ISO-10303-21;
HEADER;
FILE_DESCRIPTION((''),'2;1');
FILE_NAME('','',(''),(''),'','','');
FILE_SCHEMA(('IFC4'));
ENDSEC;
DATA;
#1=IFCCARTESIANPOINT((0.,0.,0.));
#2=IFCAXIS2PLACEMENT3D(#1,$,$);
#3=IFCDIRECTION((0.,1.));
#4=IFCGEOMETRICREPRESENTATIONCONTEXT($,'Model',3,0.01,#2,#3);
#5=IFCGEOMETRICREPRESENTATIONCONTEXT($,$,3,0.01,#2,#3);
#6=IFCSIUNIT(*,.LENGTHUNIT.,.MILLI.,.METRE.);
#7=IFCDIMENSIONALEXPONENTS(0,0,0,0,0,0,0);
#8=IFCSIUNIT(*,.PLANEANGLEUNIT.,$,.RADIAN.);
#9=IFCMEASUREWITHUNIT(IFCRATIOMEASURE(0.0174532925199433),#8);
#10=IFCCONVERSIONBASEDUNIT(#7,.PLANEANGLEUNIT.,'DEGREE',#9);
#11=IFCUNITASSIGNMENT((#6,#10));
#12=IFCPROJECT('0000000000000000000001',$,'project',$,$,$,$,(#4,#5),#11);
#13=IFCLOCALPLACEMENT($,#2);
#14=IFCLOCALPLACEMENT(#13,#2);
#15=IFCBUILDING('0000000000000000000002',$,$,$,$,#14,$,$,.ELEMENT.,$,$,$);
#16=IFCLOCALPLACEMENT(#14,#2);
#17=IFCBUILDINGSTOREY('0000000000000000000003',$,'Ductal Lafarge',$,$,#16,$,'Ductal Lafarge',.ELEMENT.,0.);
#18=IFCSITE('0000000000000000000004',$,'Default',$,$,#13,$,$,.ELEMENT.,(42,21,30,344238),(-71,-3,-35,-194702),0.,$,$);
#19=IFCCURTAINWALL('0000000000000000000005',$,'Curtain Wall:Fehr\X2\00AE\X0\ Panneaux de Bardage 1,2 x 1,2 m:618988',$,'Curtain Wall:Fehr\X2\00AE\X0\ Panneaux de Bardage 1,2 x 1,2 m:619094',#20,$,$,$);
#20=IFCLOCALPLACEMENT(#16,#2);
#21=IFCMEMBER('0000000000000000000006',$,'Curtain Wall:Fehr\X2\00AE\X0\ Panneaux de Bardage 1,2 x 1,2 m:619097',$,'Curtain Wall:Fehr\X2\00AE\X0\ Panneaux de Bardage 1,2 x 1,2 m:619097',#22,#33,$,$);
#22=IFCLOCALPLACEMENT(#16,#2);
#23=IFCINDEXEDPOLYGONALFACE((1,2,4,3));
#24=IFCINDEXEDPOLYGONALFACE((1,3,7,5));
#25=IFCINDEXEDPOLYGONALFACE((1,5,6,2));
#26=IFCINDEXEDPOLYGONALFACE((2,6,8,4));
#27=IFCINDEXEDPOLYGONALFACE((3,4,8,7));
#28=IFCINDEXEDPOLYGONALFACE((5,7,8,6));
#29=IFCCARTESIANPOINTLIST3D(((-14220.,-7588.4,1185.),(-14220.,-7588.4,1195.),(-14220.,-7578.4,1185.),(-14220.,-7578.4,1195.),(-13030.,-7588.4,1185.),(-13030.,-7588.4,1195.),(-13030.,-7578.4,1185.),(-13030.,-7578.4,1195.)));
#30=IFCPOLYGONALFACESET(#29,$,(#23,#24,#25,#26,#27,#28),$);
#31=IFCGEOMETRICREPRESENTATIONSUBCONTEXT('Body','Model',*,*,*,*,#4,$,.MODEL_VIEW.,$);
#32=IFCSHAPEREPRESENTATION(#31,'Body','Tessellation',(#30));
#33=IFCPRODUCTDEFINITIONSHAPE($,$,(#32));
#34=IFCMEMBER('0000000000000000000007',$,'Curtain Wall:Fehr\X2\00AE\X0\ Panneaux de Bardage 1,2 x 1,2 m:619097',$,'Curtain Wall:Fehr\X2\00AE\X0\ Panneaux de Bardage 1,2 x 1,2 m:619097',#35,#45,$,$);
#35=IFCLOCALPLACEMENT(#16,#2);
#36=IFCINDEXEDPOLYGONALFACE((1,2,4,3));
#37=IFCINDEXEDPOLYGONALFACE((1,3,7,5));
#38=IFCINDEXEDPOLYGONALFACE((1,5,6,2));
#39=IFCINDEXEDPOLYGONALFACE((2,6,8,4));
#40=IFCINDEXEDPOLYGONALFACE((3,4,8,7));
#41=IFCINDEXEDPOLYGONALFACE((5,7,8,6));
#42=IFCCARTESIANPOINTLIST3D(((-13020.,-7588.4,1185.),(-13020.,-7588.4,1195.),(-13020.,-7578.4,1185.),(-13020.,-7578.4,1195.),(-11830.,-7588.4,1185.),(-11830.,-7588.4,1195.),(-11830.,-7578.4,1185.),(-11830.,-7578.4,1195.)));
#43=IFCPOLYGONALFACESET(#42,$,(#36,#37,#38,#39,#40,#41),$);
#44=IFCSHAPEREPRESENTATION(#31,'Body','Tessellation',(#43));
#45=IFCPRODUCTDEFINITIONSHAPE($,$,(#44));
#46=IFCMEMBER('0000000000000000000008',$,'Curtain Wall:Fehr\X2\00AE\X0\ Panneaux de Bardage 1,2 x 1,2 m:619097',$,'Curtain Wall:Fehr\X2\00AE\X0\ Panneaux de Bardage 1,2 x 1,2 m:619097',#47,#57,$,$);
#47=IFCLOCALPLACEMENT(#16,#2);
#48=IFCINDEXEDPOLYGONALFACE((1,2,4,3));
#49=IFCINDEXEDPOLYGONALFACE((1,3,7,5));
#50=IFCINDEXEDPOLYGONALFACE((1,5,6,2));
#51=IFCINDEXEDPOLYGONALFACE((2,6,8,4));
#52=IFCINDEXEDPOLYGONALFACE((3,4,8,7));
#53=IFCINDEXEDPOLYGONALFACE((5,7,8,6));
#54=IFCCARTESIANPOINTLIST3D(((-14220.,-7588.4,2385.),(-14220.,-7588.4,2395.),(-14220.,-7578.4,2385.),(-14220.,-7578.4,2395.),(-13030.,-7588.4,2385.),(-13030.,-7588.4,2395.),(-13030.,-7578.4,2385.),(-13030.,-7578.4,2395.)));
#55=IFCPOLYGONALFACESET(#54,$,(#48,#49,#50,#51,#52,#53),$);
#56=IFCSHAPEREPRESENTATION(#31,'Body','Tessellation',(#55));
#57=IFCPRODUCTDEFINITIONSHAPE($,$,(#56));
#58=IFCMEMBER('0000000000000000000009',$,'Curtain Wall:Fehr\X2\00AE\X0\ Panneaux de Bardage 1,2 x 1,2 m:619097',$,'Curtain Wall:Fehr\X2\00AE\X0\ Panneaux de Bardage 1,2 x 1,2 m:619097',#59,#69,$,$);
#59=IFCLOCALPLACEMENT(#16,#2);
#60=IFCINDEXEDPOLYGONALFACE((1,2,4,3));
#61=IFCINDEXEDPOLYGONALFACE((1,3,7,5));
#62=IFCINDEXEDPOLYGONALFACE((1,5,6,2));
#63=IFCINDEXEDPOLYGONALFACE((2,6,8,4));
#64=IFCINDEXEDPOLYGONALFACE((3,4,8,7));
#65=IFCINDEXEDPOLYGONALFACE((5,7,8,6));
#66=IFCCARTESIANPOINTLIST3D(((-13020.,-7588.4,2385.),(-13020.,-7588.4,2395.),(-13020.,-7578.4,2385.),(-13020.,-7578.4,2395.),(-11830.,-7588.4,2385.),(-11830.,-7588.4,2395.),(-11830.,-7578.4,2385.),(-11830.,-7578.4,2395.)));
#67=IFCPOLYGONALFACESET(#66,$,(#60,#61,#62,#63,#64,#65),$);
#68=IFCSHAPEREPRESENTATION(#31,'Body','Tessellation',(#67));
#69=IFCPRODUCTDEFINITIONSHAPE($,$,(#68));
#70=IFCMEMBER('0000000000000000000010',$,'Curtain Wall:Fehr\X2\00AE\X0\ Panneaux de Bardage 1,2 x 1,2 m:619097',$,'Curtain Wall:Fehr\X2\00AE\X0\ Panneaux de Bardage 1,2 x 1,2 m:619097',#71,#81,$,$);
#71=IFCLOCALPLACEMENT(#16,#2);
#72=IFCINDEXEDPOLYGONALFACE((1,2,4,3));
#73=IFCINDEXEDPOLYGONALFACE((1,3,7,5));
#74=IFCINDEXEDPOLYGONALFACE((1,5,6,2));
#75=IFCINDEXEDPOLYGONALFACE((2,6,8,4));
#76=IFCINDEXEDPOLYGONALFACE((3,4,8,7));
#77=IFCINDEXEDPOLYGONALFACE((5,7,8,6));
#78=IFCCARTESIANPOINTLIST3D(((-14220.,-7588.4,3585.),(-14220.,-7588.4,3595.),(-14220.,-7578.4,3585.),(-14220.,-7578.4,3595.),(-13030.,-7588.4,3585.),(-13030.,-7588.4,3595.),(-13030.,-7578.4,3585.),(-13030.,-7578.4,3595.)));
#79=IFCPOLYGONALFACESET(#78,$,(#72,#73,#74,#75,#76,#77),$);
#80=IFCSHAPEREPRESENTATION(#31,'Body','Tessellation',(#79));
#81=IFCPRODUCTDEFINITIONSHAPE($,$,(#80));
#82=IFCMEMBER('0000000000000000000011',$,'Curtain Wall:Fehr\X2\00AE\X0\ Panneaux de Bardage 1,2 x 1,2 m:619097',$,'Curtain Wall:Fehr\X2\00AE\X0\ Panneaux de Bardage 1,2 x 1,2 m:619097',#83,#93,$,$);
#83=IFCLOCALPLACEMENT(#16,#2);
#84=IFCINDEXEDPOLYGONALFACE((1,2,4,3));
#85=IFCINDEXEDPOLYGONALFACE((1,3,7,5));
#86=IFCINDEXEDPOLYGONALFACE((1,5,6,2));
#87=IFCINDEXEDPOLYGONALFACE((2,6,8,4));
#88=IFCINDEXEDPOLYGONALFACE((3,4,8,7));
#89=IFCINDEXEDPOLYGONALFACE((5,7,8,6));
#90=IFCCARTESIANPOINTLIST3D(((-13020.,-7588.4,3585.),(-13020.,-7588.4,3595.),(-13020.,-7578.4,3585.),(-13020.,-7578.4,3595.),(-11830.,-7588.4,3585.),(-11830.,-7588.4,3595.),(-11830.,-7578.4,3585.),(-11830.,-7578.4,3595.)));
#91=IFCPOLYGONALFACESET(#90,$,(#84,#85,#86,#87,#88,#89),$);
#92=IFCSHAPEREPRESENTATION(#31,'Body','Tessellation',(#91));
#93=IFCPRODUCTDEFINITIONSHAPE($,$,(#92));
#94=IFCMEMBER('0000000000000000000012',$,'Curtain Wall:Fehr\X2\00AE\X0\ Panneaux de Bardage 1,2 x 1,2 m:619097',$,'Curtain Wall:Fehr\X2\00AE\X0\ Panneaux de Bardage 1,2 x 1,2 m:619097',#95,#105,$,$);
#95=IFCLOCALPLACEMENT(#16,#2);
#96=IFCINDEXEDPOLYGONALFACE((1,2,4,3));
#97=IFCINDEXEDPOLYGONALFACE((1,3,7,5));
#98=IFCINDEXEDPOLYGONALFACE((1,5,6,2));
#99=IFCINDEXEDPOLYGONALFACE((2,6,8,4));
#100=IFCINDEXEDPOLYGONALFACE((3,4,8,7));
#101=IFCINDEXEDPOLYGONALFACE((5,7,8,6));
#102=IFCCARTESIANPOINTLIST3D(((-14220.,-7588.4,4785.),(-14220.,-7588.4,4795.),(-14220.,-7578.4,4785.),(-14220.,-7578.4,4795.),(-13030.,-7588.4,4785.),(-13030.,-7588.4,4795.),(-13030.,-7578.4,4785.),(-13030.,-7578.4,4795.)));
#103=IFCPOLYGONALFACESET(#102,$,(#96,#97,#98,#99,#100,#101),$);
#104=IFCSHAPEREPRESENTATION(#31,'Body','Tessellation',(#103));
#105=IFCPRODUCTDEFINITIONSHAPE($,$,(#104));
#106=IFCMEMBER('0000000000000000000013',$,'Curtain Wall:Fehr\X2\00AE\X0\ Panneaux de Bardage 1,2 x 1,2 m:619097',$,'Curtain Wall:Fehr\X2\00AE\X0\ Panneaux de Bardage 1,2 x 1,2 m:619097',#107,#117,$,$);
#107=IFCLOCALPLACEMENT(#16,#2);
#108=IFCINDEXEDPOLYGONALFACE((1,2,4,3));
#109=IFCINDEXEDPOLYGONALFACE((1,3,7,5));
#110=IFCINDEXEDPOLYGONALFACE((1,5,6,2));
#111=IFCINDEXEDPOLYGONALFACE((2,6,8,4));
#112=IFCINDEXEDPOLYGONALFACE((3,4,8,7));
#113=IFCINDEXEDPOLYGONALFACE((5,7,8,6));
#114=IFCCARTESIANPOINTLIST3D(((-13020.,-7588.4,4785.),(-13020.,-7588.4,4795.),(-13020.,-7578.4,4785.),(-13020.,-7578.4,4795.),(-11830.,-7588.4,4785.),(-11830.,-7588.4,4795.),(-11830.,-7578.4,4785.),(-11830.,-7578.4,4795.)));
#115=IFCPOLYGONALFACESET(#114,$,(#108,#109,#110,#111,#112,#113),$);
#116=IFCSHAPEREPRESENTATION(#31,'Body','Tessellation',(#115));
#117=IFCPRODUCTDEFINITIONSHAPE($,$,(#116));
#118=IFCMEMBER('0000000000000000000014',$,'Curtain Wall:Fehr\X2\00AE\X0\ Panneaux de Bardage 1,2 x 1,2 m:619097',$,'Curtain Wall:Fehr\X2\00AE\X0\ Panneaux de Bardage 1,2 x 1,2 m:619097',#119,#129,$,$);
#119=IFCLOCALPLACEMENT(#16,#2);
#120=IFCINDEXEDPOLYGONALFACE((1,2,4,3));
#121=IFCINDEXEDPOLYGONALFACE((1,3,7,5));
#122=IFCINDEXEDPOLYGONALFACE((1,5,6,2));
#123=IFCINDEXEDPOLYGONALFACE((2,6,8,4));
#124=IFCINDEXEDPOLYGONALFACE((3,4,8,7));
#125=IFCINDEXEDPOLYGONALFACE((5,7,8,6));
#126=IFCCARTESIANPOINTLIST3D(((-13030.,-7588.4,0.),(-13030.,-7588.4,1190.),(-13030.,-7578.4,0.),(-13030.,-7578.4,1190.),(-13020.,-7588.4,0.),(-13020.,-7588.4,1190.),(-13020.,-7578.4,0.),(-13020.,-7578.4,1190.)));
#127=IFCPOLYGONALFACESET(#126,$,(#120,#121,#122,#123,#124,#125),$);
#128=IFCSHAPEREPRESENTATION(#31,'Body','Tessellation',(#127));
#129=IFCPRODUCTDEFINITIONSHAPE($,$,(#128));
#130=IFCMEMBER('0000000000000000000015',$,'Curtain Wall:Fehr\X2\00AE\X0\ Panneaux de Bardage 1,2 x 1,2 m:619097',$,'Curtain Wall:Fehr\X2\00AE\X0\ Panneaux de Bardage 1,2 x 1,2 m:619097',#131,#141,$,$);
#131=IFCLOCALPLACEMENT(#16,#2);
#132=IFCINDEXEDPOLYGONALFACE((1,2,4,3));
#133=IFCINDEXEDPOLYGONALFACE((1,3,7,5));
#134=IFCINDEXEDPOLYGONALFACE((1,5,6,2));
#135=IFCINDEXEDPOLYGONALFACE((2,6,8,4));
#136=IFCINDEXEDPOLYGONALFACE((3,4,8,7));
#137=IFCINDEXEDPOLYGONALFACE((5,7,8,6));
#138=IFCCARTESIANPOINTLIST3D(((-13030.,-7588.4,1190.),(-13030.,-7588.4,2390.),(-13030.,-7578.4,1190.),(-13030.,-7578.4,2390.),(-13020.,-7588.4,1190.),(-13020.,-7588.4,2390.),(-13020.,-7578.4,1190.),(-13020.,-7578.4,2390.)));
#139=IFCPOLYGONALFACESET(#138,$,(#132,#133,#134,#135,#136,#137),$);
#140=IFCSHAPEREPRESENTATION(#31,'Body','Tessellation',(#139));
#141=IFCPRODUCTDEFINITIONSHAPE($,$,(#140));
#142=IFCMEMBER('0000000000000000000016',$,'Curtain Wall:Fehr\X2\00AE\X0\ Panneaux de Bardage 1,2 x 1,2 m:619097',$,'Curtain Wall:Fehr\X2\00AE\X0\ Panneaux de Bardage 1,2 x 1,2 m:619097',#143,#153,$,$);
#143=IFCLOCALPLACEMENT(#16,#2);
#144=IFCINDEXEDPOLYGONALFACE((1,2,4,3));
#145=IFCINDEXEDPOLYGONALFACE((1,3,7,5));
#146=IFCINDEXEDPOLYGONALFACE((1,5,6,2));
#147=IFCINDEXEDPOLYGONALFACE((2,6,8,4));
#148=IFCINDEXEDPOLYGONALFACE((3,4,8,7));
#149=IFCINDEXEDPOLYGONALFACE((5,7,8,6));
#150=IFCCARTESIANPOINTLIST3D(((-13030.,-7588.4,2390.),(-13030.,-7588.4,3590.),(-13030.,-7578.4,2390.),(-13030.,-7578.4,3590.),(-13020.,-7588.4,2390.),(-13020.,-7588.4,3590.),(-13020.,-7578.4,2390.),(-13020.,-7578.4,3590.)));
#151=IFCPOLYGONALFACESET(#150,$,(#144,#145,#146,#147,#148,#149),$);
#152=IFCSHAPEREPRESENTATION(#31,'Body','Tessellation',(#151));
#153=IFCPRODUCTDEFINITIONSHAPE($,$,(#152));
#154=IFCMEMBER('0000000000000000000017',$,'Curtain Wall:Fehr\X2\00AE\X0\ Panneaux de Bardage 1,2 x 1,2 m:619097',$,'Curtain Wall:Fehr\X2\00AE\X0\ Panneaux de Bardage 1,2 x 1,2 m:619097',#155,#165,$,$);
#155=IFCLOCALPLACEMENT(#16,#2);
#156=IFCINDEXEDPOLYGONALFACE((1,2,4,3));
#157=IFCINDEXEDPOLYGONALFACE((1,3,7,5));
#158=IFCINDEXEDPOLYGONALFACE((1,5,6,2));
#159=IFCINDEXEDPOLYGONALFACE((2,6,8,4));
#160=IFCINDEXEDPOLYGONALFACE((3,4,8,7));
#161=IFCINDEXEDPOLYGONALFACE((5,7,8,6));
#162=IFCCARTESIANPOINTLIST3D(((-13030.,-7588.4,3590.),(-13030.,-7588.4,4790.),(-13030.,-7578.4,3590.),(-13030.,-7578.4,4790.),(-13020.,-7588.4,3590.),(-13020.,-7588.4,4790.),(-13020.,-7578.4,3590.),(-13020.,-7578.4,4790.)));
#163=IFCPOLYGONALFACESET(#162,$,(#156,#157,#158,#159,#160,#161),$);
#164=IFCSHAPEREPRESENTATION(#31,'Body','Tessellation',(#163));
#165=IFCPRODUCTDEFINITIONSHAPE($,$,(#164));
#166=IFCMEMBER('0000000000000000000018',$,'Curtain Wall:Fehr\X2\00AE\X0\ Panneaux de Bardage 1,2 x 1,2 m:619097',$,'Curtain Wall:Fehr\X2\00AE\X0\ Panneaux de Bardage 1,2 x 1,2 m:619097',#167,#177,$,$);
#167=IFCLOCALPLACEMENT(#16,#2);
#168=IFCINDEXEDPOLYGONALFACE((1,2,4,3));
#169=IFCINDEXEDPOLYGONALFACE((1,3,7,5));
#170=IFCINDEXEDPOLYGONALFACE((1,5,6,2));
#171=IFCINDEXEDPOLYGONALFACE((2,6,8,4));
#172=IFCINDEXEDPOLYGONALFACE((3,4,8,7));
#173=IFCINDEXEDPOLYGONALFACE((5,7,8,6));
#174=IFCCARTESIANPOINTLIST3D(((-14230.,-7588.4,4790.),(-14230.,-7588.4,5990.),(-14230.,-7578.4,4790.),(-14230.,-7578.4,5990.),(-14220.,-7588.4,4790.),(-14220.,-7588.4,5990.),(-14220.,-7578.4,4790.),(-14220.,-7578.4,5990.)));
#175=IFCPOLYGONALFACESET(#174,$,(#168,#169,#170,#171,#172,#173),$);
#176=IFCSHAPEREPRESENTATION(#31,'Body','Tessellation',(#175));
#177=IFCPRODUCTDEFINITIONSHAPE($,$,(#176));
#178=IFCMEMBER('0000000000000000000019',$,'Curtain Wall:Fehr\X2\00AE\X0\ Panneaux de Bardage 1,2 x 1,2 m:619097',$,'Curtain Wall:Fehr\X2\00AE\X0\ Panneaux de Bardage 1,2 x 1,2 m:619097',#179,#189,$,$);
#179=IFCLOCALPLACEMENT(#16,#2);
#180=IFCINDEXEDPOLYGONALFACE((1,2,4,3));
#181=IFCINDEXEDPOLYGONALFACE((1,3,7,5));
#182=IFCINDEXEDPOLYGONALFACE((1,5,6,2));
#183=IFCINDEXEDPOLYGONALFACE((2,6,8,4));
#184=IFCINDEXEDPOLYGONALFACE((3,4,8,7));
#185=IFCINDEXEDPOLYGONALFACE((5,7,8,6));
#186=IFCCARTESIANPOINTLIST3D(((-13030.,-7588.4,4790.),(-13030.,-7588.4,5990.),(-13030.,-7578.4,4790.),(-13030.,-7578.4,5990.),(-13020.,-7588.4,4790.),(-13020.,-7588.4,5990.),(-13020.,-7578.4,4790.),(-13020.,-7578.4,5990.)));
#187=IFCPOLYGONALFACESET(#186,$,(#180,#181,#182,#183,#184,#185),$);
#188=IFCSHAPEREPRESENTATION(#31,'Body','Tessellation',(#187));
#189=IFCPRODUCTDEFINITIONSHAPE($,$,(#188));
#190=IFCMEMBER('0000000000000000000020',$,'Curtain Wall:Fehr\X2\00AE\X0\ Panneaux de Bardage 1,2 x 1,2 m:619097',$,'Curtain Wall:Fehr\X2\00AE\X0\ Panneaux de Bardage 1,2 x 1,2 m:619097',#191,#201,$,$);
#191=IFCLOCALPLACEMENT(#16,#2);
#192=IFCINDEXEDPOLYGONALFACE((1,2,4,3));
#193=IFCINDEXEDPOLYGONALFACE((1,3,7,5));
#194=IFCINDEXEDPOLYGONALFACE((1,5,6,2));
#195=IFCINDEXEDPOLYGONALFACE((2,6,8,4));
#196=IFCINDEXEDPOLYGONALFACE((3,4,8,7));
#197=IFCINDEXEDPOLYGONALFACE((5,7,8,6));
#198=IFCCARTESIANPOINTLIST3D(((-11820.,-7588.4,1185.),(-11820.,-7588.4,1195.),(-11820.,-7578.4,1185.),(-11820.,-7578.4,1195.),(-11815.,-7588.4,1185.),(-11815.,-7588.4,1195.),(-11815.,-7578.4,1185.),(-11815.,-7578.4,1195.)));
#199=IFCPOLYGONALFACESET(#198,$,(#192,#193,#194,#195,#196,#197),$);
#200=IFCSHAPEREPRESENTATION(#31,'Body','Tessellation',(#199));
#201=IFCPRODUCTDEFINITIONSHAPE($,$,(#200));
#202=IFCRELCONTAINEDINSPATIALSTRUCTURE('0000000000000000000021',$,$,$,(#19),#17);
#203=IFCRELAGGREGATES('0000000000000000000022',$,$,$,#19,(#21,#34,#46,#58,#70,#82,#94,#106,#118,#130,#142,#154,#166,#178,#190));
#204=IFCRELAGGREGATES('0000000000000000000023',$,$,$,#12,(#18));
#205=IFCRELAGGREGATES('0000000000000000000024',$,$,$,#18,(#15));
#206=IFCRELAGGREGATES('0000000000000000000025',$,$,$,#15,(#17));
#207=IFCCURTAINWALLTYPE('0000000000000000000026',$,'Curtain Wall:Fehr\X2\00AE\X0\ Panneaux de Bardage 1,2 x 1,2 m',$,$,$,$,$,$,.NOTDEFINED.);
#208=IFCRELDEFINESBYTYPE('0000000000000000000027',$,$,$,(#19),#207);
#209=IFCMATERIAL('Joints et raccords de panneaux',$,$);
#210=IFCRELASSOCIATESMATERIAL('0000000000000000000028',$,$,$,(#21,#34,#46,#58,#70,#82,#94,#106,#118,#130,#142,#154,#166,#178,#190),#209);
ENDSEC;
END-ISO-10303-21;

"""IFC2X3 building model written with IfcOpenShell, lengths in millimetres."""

from ifc_helpers import new_model, entity, si_unit, converted_unit, direction, frame, frame_2d, origin, origin_2d_with_axis, place, context, subcontext, project, spatial, rectangle, extrude, material, type_object, element, aggregate, save


model = new_model("IFC2X3")

# Units and contexts
model_context = context("Model", 3, precision=0.01, world=origin(), true_north=direction((0.0, 1.0)))
context_of_model = context(None, 3, precision=0.01, world=origin(), true_north=direction((0.0, 1.0)))
body_context = subcontext(model_context, "Body", "Model", "MODEL_VIEW")
ifc_project = project(units=[si_unit("LENGTHUNIT", "METRE", prefix="MILLI"), converted_unit("PLANEANGLEUNIT", "DEGREE", entity("IfcRatioMeasure", 0.0174532925199433), si_unit("PLANEANGLEUNIT", "RADIAN"), dimensions=[0, 0, 0, 0, 0, 0, 0])], contexts=[model_context, context_of_model])

# Site, building, storey
site_placement = place(None, origin())
site = spatial("IfcSite", under=ifc_project, at=site_placement, Name="Default", CompositionType="ELEMENT", RefLatitude=(42, 21, 30, 344238), RefLongitude=(-71, -3, -35, -194702), RefElevation=0.0)
building_placement = place(site_placement, origin())
building = spatial("IfcBuilding", under=site, at=building_placement, CompositionType="ELEMENT")
storey_placement = place(building_placement, origin())
storey = spatial("IfcBuildingStorey", under=building, at=storey_placement, Name="Ductal Lafarge", LongName="Ductal Lafarge", CompositionType="ELEMENT", Elevation=0.0)

# Curtain wall, members
curtain_wall_type = type_object("IfcCurtainWallType", Name="Curtain Wall:Fehr® Panneaux de Bardage 1,2 x 1,2 m", PredefinedType="NOTDEFINED")
curtain_wall_placement = place(storey_placement, origin())
curtain_wall = element("IfcCurtainWall", 1, at=curtain_wall_placement, inside=storey, type_object=curtain_wall_type, Name="Curtain Wall:Fehr® Panneaux de Bardage 1,2 x 1,2 m:618988", ObjectType="Curtain Wall:Fehr® Panneaux de Bardage 1,2 x 1,2 m:619094")
ifc_material = material(Name="Joints et raccords de panneaux")
member_1_placement = place(curtain_wall_placement, frame((-14220.0, -7588.4, 1185.0)))
member_1 = element("IfcMember", 2, at=member_1_placement, material=ifc_material, Name="Curtain Wall:Fehr® Panneaux de Bardage 1,2 x 1,2 m:619097", ObjectType="Curtain Wall:Fehr® Panneaux de Bardage 1,2 x 1,2 m:619097", context=body_context, shape_type="SweptSolid", body=[
    extrude(rectangle(XDim=1190.0, YDim=10.0, at=frame_2d((0.0, 0.0), x_axis=(1.0, 0.0))), frame((595.0, 5.0, 0.0), z_axis=(0.0, 0.0, 1.0), x_axis=(-1.0, 0.0, 0.0)), (0.0, 0.0, 1.0), 10.0),
])
member_2_placement = place(curtain_wall_placement, frame((-13020.0, -7588.4, 1185.0)))
member_2 = element("IfcMember", 3, at=member_2_placement, material=ifc_material, Name="Curtain Wall:Fehr® Panneaux de Bardage 1,2 x 1,2 m:619097", ObjectType="Curtain Wall:Fehr® Panneaux de Bardage 1,2 x 1,2 m:619097", context=body_context, shape_type="SweptSolid", body=[
    extrude(rectangle(XDim=1190.0, YDim=10.0, at=frame_2d((0.0, 0.0), x_axis=(1.0, 0.0))), frame((595.0, 5.0, 0.0), z_axis=(0.0, 0.0, 1.0), x_axis=(-1.0, 0.0, 0.0)), (0.0, 0.0, 1.0), 10.0),
])
member_3_placement = place(curtain_wall_placement, frame((-14220.0, -7588.4, 2385.0)))
member_3 = element("IfcMember", 4, at=member_3_placement, material=ifc_material, Name="Curtain Wall:Fehr® Panneaux de Bardage 1,2 x 1,2 m:619097", ObjectType="Curtain Wall:Fehr® Panneaux de Bardage 1,2 x 1,2 m:619097", context=body_context, shape_type="SweptSolid", body=[
    extrude(rectangle(XDim=1190.0, YDim=10.0, at=frame_2d((0.0, 0.0), x_axis=(1.0, 0.0))), frame((595.0, 5.0, 0.0), z_axis=(0.0, 0.0, 1.0), x_axis=(-1.0, 0.0, 0.0)), (0.0, 0.0, 1.0), 10.0),
])
member_4_placement = place(curtain_wall_placement, frame((-13020.0, -7588.4, 2385.0)))
member_4 = element("IfcMember", 5, at=member_4_placement, material=ifc_material, Name="Curtain Wall:Fehr® Panneaux de Bardage 1,2 x 1,2 m:619097", ObjectType="Curtain Wall:Fehr® Panneaux de Bardage 1,2 x 1,2 m:619097", context=body_context, shape_type="SweptSolid", body=[
    extrude(rectangle(XDim=1190.0, YDim=10.0, at=frame_2d((0.0, 0.0), x_axis=(1.0, 0.0))), frame((595.0, 5.0, 0.0), z_axis=(0.0, 0.0, 1.0), x_axis=(-1.0, 0.0, 0.0)), (0.0, 0.0, 1.0), 10.0),
])
member_5_placement = place(curtain_wall_placement, frame((-14220.0, -7588.4, 3585.0)))
member_5 = element("IfcMember", 6, at=member_5_placement, material=ifc_material, Name="Curtain Wall:Fehr® Panneaux de Bardage 1,2 x 1,2 m:619097", ObjectType="Curtain Wall:Fehr® Panneaux de Bardage 1,2 x 1,2 m:619097", context=body_context, shape_type="SweptSolid", body=[
    extrude(rectangle(XDim=1190.0, YDim=10.0, at=frame_2d((0.0, 0.0), x_axis=(1.0, 0.0))), frame((595.0, 5.0, 0.0), z_axis=(0.0, 0.0, 1.0), x_axis=(-1.0, 0.0, 0.0)), (0.0, 0.0, 1.0), 10.0),
])
member_6_placement = place(curtain_wall_placement, frame((-13020.0, -7588.4, 3585.0)))
member_6 = element("IfcMember", 7, at=member_6_placement, material=ifc_material, Name="Curtain Wall:Fehr® Panneaux de Bardage 1,2 x 1,2 m:619097", ObjectType="Curtain Wall:Fehr® Panneaux de Bardage 1,2 x 1,2 m:619097", context=body_context, shape_type="SweptSolid", body=[
    extrude(rectangle(XDim=1190.0, YDim=10.0, at=frame_2d((0.0, 0.0), x_axis=(1.0, 0.0))), frame((595.0, 5.0, 0.0), z_axis=(0.0, 0.0, 1.0), x_axis=(-1.0, 0.0, 0.0)), (0.0, 0.0, 1.0), 10.0),
])
member_7_placement = place(curtain_wall_placement, frame((-14220.0, -7588.4, 4785.0)))
member_7 = element("IfcMember", 8, at=member_7_placement, material=ifc_material, Name="Curtain Wall:Fehr® Panneaux de Bardage 1,2 x 1,2 m:619097", ObjectType="Curtain Wall:Fehr® Panneaux de Bardage 1,2 x 1,2 m:619097", context=body_context, shape_type="SweptSolid", body=[
    extrude(rectangle(XDim=1190.0, YDim=10.0, at=frame_2d((0.0, 0.0), x_axis=(1.0, 0.0))), frame((595.0, 5.0, 0.0), z_axis=(0.0, 0.0, 1.0), x_axis=(-1.0, 0.0, 0.0)), (0.0, 0.0, 1.0), 10.0),
])
member_8_placement = place(curtain_wall_placement, frame((-13020.0, -7588.4, 4785.0)))
member_8 = element("IfcMember", 9, at=member_8_placement, material=ifc_material, Name="Curtain Wall:Fehr® Panneaux de Bardage 1,2 x 1,2 m:619097", ObjectType="Curtain Wall:Fehr® Panneaux de Bardage 1,2 x 1,2 m:619097", context=body_context, shape_type="SweptSolid", body=[
    extrude(rectangle(XDim=1190.0, YDim=10.0, at=frame_2d((0.0, 0.0), x_axis=(1.0, 0.0))), frame((595.0, 5.0, 0.0), z_axis=(0.0, 0.0, 1.0), x_axis=(-1.0, 0.0, 0.0)), (0.0, 0.0, 1.0), 10.0),
])
member_9_placement = place(curtain_wall_placement, frame((-13030.0, -7588.4, 0.0)))
member_9 = element("IfcMember", 10, at=member_9_placement, material=ifc_material, Name="Curtain Wall:Fehr® Panneaux de Bardage 1,2 x 1,2 m:619097", ObjectType="Curtain Wall:Fehr® Panneaux de Bardage 1,2 x 1,2 m:619097", context=body_context, shape_type="SweptSolid", body=[
    extrude(rectangle(XDim=10.0, YDim=10.0, at=origin_2d_with_axis()), frame((5.0, 5.0, 0.0), z_axis=(0.0, 0.0, 1.0), x_axis=(0.0, 1.0, 0.0)), (0.0, 0.0, 1.0), 1190.0),
])
member_10_placement = place(curtain_wall_placement, frame((-13030.0, -7588.4, 1190.0)))
member_10 = element("IfcMember", 11, at=member_10_placement, material=ifc_material, Name="Curtain Wall:Fehr® Panneaux de Bardage 1,2 x 1,2 m:619097", ObjectType="Curtain Wall:Fehr® Panneaux de Bardage 1,2 x 1,2 m:619097", context=body_context, shape_type="SweptSolid", body=[
    extrude(rectangle(XDim=10.0, YDim=10.0, at=origin_2d_with_axis()), frame((5.0, 5.0, 0.0), z_axis=(0.0, 0.0, 1.0), x_axis=(0.0, 1.0, 0.0)), (0.0, 0.0, 1.0), 1200.0),
])
member_11_placement = place(curtain_wall_placement, frame((-13030.0, -7588.4, 2390.0)))
member_11 = element("IfcMember", 12, at=member_11_placement, material=ifc_material, Name="Curtain Wall:Fehr® Panneaux de Bardage 1,2 x 1,2 m:619097", ObjectType="Curtain Wall:Fehr® Panneaux de Bardage 1,2 x 1,2 m:619097", context=body_context, shape_type="SweptSolid", body=[
    extrude(rectangle(XDim=10.0, YDim=10.0, at=origin_2d_with_axis()), frame((5.0, 5.0, 0.0), z_axis=(0.0, 0.0, 1.0), x_axis=(0.0, 1.0, 0.0)), (0.0, 0.0, 1.0), 1200.0),
])
member_12_placement = place(curtain_wall_placement, frame((-13030.0, -7588.4, 3590.0)))
member_12 = element("IfcMember", 13, at=member_12_placement, material=ifc_material, Name="Curtain Wall:Fehr® Panneaux de Bardage 1,2 x 1,2 m:619097", ObjectType="Curtain Wall:Fehr® Panneaux de Bardage 1,2 x 1,2 m:619097", context=body_context, shape_type="SweptSolid", body=[
    extrude(rectangle(XDim=10.0, YDim=10.0, at=origin_2d_with_axis()), frame((5.0, 5.0, 0.0), z_axis=(0.0, 0.0, 1.0), x_axis=(0.0, 1.0, 0.0)), (0.0, 0.0, 1.0), 1200.0),
])
member_13_placement = place(curtain_wall_placement, frame((-14230.0, -7588.4, 4790.0)))
member_13 = element("IfcMember", 14, at=member_13_placement, material=ifc_material, Name="Curtain Wall:Fehr® Panneaux de Bardage 1,2 x 1,2 m:619097", ObjectType="Curtain Wall:Fehr® Panneaux de Bardage 1,2 x 1,2 m:619097", context=body_context, shape_type="SweptSolid", body=[
    extrude(rectangle(XDim=10.0, YDim=10.0, at=origin_2d_with_axis()), frame((5.0, 5.0, 0.0), z_axis=(0.0, 0.0, 1.0), x_axis=(0.0, 1.0, 0.0)), (0.0, 0.0, 1.0), 1200.0),
])
member_14_placement = place(curtain_wall_placement, frame((-13030.0, -7588.4, 4790.0)))
member_14 = element("IfcMember", 15, at=member_14_placement, material=ifc_material, Name="Curtain Wall:Fehr® Panneaux de Bardage 1,2 x 1,2 m:619097", ObjectType="Curtain Wall:Fehr® Panneaux de Bardage 1,2 x 1,2 m:619097", context=body_context, shape_type="SweptSolid", body=[
    extrude(rectangle(XDim=10.0, YDim=10.0, at=origin_2d_with_axis()), frame((5.0, 5.0, 0.0), z_axis=(0.0, 0.0, 1.0), x_axis=(0.0, 1.0, 0.0)), (0.0, 0.0, 1.0), 1200.0),
])
member_15_placement = place(curtain_wall_placement, frame((-11820.0, -7588.4, 1185.0)))
member_15 = element("IfcMember", 16, at=member_15_placement, material=ifc_material, Name="Curtain Wall:Fehr® Panneaux de Bardage 1,2 x 1,2 m:619097", ObjectType="Curtain Wall:Fehr® Panneaux de Bardage 1,2 x 1,2 m:619097", context=body_context, shape_type="SweptSolid", body=[
    extrude(rectangle(XDim=5.0, YDim=10.0, at=origin_2d_with_axis()), frame((2.5, 5.0, 0.0), z_axis=(0.0, 0.0, 1.0), x_axis=(-1.0, 0.0, 0.0)), (0.0, 0.0, 1.0), 10.0),
])
aggregate(curtain_wall, [member_1, member_2, member_3, member_4, member_5, member_6, member_7, member_8, member_9, member_10, member_11, member_12, member_13, member_14, member_15])

save(model, "model.ifc")
